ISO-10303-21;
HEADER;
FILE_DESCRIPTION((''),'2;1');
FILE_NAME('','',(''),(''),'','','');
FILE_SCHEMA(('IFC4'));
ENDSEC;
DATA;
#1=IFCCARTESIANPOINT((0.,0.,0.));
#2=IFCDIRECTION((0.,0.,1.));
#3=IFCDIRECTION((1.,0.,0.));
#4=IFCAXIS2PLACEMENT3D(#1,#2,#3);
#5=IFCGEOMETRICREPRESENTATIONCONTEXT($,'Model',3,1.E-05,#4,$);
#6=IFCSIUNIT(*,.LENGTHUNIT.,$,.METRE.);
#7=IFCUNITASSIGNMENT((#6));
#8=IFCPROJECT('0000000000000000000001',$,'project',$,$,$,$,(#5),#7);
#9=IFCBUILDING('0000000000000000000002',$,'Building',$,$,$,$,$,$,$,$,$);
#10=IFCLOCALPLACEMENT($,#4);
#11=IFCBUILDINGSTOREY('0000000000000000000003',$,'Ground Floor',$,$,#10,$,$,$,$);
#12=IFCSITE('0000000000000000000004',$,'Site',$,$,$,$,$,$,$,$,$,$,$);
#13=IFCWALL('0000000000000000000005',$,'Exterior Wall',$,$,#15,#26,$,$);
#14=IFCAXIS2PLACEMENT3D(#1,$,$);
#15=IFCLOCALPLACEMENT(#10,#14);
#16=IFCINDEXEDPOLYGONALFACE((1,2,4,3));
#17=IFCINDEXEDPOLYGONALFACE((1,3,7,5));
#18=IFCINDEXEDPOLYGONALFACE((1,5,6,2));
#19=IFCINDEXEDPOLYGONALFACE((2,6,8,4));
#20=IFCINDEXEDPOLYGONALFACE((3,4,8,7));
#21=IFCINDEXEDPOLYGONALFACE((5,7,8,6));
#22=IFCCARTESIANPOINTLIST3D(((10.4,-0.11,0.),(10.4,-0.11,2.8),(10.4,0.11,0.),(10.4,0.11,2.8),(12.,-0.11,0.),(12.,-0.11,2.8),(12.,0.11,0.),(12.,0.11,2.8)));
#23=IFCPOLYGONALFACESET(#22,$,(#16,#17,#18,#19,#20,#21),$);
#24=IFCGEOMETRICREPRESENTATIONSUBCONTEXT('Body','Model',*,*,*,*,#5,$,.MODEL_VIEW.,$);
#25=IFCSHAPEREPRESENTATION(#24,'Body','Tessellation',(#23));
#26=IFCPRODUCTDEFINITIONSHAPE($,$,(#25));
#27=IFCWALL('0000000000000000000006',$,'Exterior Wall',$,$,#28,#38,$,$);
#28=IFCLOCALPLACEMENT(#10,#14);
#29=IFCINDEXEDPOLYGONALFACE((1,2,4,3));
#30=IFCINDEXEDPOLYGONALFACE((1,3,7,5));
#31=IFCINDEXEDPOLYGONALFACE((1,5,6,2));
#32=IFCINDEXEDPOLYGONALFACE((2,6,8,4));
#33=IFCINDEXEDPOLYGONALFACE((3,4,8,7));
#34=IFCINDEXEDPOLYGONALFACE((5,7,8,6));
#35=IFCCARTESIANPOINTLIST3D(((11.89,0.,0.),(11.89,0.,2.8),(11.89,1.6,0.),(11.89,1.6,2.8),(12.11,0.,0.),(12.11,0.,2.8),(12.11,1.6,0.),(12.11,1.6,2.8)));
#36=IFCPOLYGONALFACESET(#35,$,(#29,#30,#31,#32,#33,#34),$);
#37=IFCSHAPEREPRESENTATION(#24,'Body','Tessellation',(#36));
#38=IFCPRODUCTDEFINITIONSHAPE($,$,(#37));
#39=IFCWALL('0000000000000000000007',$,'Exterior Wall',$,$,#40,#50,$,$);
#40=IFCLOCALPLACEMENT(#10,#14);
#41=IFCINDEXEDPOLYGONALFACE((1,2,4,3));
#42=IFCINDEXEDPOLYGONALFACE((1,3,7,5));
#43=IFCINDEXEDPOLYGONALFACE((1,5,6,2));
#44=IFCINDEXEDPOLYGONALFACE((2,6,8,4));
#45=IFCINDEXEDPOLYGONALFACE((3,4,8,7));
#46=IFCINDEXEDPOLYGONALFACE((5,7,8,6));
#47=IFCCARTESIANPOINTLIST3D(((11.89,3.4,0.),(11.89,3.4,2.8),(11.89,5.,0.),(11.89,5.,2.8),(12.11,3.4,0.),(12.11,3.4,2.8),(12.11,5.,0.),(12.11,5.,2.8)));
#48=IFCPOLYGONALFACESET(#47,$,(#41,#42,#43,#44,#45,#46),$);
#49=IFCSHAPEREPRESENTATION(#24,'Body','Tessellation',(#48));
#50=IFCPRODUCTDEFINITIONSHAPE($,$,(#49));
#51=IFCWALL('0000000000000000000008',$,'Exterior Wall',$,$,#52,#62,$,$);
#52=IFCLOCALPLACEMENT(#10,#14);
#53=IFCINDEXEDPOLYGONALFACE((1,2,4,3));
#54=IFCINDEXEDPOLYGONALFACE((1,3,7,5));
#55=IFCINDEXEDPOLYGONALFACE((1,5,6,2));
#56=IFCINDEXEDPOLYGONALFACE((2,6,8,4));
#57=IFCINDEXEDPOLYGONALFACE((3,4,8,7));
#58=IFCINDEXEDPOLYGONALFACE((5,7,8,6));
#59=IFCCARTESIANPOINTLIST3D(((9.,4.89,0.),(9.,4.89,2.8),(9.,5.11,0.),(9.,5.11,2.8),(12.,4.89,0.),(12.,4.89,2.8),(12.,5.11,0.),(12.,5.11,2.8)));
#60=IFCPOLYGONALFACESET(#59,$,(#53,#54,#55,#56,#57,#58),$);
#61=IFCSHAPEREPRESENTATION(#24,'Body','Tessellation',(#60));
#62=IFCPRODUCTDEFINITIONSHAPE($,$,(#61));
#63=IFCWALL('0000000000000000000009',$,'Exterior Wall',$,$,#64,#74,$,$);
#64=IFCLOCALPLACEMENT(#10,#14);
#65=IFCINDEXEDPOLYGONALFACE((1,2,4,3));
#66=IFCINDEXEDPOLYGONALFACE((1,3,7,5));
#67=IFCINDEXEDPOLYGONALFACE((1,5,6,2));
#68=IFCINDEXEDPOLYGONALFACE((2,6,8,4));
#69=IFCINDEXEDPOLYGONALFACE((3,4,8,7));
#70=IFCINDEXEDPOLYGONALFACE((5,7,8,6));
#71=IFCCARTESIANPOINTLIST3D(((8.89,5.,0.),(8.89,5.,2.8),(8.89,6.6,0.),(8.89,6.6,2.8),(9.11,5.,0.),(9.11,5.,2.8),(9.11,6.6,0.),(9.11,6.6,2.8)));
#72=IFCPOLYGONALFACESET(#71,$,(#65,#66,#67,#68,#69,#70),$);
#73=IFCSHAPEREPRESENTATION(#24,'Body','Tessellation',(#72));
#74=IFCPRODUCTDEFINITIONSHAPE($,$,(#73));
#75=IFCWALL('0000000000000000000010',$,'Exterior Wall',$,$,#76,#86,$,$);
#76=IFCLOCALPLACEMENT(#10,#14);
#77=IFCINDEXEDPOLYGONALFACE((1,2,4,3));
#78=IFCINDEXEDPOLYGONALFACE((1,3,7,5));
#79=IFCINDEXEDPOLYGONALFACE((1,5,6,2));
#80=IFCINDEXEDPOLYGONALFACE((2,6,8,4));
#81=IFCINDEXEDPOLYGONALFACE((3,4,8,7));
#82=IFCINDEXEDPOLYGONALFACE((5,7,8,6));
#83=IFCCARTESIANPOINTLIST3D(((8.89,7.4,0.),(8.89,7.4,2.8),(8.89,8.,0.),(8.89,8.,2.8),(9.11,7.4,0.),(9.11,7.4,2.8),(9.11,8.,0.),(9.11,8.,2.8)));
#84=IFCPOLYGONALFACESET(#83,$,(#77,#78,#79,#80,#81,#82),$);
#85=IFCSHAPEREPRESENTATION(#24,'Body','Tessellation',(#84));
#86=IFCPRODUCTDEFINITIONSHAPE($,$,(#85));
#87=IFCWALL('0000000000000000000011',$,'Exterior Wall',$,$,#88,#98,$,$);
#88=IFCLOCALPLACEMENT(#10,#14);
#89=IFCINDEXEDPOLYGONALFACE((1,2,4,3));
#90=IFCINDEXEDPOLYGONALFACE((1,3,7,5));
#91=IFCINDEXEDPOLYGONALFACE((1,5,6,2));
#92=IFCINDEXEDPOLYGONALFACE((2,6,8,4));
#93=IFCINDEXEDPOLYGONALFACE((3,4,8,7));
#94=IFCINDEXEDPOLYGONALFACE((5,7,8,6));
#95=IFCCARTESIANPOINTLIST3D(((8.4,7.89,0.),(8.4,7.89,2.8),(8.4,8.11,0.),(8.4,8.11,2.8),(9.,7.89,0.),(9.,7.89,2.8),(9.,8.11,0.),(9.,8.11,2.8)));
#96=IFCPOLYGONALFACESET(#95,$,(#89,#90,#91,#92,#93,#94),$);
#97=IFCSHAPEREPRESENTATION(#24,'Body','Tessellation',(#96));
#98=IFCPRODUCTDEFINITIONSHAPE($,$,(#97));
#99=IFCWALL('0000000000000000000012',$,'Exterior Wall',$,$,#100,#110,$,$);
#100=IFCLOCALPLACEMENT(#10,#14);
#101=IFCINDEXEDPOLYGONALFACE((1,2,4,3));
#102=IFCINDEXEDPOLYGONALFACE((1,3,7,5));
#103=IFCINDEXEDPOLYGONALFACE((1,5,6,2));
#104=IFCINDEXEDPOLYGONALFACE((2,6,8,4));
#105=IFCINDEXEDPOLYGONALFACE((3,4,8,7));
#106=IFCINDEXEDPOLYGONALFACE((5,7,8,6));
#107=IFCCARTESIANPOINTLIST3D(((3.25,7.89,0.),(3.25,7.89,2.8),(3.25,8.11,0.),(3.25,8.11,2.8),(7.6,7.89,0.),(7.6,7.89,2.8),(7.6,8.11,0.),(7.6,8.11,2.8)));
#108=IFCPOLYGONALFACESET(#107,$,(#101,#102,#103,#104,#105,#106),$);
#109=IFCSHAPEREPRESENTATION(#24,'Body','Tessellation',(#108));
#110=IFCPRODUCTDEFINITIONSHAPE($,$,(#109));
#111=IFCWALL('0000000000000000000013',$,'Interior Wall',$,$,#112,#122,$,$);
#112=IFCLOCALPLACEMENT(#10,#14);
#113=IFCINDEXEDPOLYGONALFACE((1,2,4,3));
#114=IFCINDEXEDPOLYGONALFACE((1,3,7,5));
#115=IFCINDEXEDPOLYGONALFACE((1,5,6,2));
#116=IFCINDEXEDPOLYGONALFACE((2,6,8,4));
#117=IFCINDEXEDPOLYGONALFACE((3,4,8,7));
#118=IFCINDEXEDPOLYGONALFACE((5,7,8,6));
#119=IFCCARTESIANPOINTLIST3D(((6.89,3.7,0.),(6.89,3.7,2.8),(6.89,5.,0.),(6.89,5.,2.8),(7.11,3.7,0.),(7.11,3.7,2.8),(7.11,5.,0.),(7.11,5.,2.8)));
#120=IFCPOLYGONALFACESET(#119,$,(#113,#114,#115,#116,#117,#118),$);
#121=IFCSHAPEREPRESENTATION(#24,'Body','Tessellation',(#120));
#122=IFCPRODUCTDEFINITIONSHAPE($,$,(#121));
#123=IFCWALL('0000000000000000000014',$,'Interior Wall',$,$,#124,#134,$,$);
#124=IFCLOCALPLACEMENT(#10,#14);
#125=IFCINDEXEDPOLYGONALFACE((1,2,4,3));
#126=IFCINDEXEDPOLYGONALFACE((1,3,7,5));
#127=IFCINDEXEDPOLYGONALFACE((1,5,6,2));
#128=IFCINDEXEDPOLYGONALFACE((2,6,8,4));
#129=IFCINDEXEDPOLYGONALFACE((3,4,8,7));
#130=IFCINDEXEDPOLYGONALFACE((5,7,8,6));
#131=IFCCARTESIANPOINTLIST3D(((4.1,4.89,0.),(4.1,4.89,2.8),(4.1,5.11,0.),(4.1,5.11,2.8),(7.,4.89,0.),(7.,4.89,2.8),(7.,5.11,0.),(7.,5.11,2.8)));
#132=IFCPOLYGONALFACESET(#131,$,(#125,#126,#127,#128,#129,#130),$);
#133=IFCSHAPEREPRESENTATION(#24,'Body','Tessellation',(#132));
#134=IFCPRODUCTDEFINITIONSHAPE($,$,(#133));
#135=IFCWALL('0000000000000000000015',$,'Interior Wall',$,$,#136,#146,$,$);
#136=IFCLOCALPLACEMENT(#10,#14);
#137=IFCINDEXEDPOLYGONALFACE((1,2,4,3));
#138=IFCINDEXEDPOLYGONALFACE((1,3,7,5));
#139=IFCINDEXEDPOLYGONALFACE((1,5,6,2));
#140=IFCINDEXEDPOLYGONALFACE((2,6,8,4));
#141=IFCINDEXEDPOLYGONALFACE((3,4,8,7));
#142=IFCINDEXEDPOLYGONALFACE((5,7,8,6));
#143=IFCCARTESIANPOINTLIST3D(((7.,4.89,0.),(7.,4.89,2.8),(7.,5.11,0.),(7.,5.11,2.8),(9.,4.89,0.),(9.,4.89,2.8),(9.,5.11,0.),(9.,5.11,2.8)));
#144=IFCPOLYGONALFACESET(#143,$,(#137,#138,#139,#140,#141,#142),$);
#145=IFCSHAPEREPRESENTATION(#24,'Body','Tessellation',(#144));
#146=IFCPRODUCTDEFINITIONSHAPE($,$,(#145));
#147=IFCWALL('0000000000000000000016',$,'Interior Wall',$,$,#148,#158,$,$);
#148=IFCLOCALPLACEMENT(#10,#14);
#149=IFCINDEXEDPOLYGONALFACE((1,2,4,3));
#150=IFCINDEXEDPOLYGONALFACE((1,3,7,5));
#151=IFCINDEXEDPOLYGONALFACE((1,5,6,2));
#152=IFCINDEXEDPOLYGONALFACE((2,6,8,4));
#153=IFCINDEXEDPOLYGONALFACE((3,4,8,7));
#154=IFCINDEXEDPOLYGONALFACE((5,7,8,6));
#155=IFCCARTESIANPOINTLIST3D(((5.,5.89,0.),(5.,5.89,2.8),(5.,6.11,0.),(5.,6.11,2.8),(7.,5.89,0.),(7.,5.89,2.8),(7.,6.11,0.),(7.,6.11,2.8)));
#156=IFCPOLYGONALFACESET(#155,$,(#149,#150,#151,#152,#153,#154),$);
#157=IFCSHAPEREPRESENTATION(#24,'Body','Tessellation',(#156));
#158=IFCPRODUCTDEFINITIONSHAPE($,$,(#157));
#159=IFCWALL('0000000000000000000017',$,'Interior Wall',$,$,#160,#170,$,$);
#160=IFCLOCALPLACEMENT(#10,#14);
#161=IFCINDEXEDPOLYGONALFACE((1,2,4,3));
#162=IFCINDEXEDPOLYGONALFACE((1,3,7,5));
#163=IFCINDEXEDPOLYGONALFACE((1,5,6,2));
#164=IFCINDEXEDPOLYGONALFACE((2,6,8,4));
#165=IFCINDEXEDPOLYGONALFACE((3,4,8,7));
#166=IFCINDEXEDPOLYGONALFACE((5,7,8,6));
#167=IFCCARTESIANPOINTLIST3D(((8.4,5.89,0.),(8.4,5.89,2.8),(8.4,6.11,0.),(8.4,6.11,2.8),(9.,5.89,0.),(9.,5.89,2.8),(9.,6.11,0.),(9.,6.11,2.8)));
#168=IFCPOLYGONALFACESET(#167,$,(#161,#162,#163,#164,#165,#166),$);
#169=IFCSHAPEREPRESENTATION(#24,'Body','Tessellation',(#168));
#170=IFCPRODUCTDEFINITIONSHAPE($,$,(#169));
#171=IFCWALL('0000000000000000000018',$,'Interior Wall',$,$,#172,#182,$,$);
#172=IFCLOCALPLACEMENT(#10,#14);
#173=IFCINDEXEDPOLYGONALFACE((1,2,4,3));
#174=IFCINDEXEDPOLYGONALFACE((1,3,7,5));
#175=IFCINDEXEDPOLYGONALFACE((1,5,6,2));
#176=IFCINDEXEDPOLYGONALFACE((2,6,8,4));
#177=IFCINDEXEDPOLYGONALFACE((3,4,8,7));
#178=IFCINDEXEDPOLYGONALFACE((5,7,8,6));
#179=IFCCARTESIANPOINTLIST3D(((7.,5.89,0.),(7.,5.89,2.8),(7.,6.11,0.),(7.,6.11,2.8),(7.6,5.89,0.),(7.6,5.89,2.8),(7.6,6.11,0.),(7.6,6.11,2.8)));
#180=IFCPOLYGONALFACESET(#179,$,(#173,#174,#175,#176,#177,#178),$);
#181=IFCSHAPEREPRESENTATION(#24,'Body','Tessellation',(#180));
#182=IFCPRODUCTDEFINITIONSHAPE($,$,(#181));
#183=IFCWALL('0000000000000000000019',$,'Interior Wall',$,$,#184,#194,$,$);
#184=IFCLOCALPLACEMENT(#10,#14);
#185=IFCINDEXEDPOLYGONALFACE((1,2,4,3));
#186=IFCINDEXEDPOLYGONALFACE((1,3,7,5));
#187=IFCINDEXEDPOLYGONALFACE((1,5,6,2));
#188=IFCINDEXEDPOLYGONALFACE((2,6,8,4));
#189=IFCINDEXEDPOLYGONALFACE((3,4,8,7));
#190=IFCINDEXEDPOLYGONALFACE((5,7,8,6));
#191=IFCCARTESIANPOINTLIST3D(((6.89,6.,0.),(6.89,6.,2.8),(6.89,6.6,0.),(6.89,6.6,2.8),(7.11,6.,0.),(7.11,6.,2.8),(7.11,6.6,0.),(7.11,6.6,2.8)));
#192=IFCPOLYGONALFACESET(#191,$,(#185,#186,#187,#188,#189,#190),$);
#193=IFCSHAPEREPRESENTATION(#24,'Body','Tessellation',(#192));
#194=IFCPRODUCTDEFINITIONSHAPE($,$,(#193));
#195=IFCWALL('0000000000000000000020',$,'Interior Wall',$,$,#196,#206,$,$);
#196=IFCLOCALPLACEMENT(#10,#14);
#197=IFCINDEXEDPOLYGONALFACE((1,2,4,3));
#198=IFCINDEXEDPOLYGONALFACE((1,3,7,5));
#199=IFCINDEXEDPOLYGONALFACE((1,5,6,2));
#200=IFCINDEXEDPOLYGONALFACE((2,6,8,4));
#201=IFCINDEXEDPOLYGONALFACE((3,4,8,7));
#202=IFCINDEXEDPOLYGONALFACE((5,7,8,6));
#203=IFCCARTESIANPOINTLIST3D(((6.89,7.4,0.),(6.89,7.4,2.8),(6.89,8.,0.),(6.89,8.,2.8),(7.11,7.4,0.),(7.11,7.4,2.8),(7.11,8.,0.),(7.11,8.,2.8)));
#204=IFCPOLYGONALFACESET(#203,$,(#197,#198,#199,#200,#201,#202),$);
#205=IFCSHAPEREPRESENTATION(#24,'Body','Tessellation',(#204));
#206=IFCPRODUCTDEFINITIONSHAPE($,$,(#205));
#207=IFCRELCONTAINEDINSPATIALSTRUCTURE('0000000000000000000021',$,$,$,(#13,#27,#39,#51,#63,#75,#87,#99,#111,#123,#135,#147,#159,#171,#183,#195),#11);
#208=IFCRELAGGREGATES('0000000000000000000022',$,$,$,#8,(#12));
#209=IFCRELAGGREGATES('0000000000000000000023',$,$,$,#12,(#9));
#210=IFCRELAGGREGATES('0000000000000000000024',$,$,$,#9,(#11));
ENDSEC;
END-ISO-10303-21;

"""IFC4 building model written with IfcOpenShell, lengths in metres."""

from ifc_helpers import new_model, si_unit, frame, origin_with_axes, place, context, subcontext, project, spatial, indexed_curve, outline, extrude, element, save


model = new_model("IFC4")

# Units and contexts
model_context = context("Model", 3, precision=1e-05, world=origin_with_axes())
body_context = subcontext(model_context, "Body", "Model", "MODEL_VIEW")
ifc_project = project(units=[si_unit("LENGTHUNIT", "METRE")], contexts=[model_context])

# Site, building, storey
site = spatial("IfcSite", under=ifc_project, Name="Site")
building = spatial("IfcBuilding", under=site, Name="Building")
storey_placement = place(None, origin_with_axes())
storey = spatial("IfcBuildingStorey", under=building, at=storey_placement, Name="Ground Floor")

# Walls
wall_1_placement = place(storey_placement, frame((10.4, 0.0, 0.0), z_axis=(0.0, 0.0, 1.0), x_axis=(1.0, 0.0, 0.0)))
element("IfcWall", 1, at=wall_1_placement, inside=storey, Name="Exterior Wall", context=body_context, shape_type="SweptSolid", body=[
    extrude(outline(indexed_curve([(0.0, 0.0), (0.0, 0.22), (1.6, 0.22), (1.6, 0.0), (0.0, 0.0)], self_intersect=False)), frame((0.0, -0.11, 0.0), z_axis=(0.0, 0.0, 1.0), x_axis=(1.0, 0.0, 0.0)), (0.0, 0.0, 1.0), 2.8),
])
for number, where, z_axis, x_axis, name in (
    (2, (12.0, 0.0, 0.0), (0.0, 0.0, 1.0), (0.0, 1.0, 0.0), "Exterior Wall"),
    (3, (12.0, 3.4, 0.0), (0.0, 0.0, 1.0), (0.0, 1.0, 0.0), "Exterior Wall"),
):
    element("IfcWall", number, at=place(storey_placement, frame(where, z_axis=z_axis, x_axis=x_axis)), inside=storey, Name=name, context=body_context, shape_type="SweptSolid", body=[
        extrude(outline(indexed_curve([(0.0, 0.0), (0.0, 0.22), (1.6, 0.22), (1.6, 0.0), (0.0, 0.0)], self_intersect=False)), frame((0.0, -0.11, 0.0), z_axis=(0.0, 0.0, 1.0), x_axis=(1.0, 0.0, 0.0)), (0.0, 0.0, 1.0), 2.8),
    ])
wall_2_placement = place(storey_placement, frame((12.0, 5.0, 0.0), z_axis=(0.0, 0.0, 1.0), x_axis=(-1.0, 0.0, 0.0)))
element("IfcWall", 4, at=wall_2_placement, inside=storey, Name="Exterior Wall", context=body_context, shape_type="SweptSolid", body=[
    extrude(outline(indexed_curve([(0.0, 0.0), (0.0, 0.22), (3.0, 0.22), (3.0, 0.0), (0.0, 0.0)], self_intersect=False)), frame((0.0, -0.11, 0.0), z_axis=(0.0, 0.0, 1.0), x_axis=(1.0, 0.0, 0.0)), (0.0, 0.0, 1.0), 2.8),
])
wall_3_placement = place(storey_placement, frame((9.0, 5.0, 0.0), z_axis=(0.0, 0.0, 1.0), x_axis=(0.0, 1.0, 0.0)))
element("IfcWall", 5, at=wall_3_placement, inside=storey, Name="Exterior Wall", context=body_context, shape_type="SweptSolid", body=[
    extrude(outline(indexed_curve([(0.0, 0.0), (0.0, 0.22), (1.6, 0.22), (1.6, 0.0), (0.0, 0.0)], self_intersect=False)), frame((0.0, -0.11, 0.0), z_axis=(0.0, 0.0, 1.0), x_axis=(1.0, 0.0, 0.0)), (0.0, 0.0, 1.0), 2.8),
])
for number, where, z_axis, x_axis, name in (
    (6, (9.0, 7.4, 0.0), (0.0, 0.0, 1.0), (0.0, 1.0, 0.0), "Exterior Wall"),
    (7, (9.0, 8.0, 0.0), (0.0, 0.0, 1.0), (-1.0, 0.0, 0.0), "Exterior Wall"),
):
    element("IfcWall", number, at=place(storey_placement, frame(where, z_axis=z_axis, x_axis=x_axis)), inside=storey, Name=name, context=body_context, shape_type="SweptSolid", body=[
        extrude(outline(indexed_curve([(0.0, 0.0), (0.0, 0.22), (0.6, 0.22), (0.6, 0.0), (0.0, 0.0)], self_intersect=False)), frame((0.0, -0.11, 0.0), z_axis=(0.0, 0.0, 1.0), x_axis=(1.0, 0.0, 0.0)), (0.0, 0.0, 1.0), 2.8),
    ])
wall_4_placement = place(storey_placement, frame((7.6, 8.0, 0.0), z_axis=(0.0, 0.0, 1.0), x_axis=(-1.0, 0.0, 0.0)))
element("IfcWall", 8, at=wall_4_placement, inside=storey, Name="Exterior Wall", context=body_context, shape_type="SweptSolid", body=[
    extrude(outline(indexed_curve([(0.0, 0.0), (0.0, 0.22), (4.35, 0.22), (4.35, 0.0), (0.0, 0.0)], self_intersect=False)), frame((0.0, -0.11, 0.0), z_axis=(0.0, 0.0, 1.0), x_axis=(1.0, 0.0, 0.0)), (0.0, 0.0, 1.0), 2.8),
])
wall_5_placement = place(storey_placement, frame((7.0, 3.7, 0.0), z_axis=(0.0, 0.0, 1.0), x_axis=(0.0, 1.0, 0.0)))
element("IfcWall", 9, at=wall_5_placement, inside=storey, Name="Interior Wall", context=body_context, shape_type="SweptSolid", body=[
    extrude(outline(indexed_curve([(0.0, 0.0), (0.0, 0.22), (1.3, 0.22), (1.3, 0.0), (0.0, 0.0)], self_intersect=False)), frame((0.0, -0.11, 0.0), z_axis=(0.0, 0.0, 1.0), x_axis=(1.0, 0.0, 0.0)), (0.0, 0.0, 1.0), 2.8),
])
wall_6_placement = place(storey_placement, frame((7.0, 5.0, 0.0), z_axis=(0.0, 0.0, 1.0), x_axis=(-1.0, 0.0, 0.0)))
element("IfcWall", 10, at=wall_6_placement, inside=storey, Name="Interior Wall", context=body_context, shape_type="SweptSolid", body=[
    extrude(outline(indexed_curve([(0.0, 0.0), (0.0, 0.22), (2.9, 0.22), (2.9, 0.0), (0.0, 0.0)], self_intersect=False)), frame((0.0, -0.11, 0.0), z_axis=(0.0, 0.0, 1.0), x_axis=(1.0, 0.0, 0.0)), (0.0, 0.0, 1.0), 2.8),
])
for number, where, z_axis, x_axis, name in (
    (11, (9.0, 5.0, 0.0), (0.0, 0.0, 1.0), (-1.0, 0.0, 0.0), "Interior Wall"),
    (12, (7.0, 6.0, 0.0), (0.0, 0.0, 1.0), (-1.0, 0.0, 0.0), "Interior Wall"),
):
    element("IfcWall", number, at=place(storey_placement, frame(where, z_axis=z_axis, x_axis=x_axis)), inside=storey, Name=name, context=body_context, shape_type="SweptSolid", body=[
        extrude(outline(indexed_curve([(0.0, 0.0), (0.0, 0.22), (2.0, 0.22), (2.0, 0.0), (0.0, 0.0)], self_intersect=False)), frame((0.0, -0.11, 0.0), z_axis=(0.0, 0.0, 1.0), x_axis=(1.0, 0.0, 0.0)), (0.0, 0.0, 1.0), 2.8),
    ])
for number, where, z_axis, x_axis, name in (
    (13, (9.0, 6.0, 0.0), (0.0, 0.0, 1.0), (-1.0, 0.0, 0.0), "Interior Wall"),
    (14, (7.6, 6.0, 0.0), (0.0, 0.0, 1.0), (-1.0, 0.0, 0.0), "Interior Wall"),
    (15, (7.0, 6.0, 0.0), (0.0, 0.0, 1.0), (0.0, 1.0, 0.0), "Interior Wall"),
    (16, (7.0, 7.4, 0.0), (0.0, 0.0, 1.0), (0.0, 1.0, 0.0), "Interior Wall"),
):
    element("IfcWall", number, at=place(storey_placement, frame(where, z_axis=z_axis, x_axis=x_axis)), inside=storey, Name=name, context=body_context, shape_type="SweptSolid", body=[
        extrude(outline(indexed_curve([(0.0, 0.0), (0.0, 0.22), (0.6, 0.22), (0.6, 0.0), (0.0, 0.0)], self_intersect=False)), frame((0.0, -0.11, 0.0), z_axis=(0.0, 0.0, 1.0), x_axis=(1.0, 0.0, 0.0)), (0.0, 0.0, 1.0), 2.8),
    ])

save(model, "model.ifc")
